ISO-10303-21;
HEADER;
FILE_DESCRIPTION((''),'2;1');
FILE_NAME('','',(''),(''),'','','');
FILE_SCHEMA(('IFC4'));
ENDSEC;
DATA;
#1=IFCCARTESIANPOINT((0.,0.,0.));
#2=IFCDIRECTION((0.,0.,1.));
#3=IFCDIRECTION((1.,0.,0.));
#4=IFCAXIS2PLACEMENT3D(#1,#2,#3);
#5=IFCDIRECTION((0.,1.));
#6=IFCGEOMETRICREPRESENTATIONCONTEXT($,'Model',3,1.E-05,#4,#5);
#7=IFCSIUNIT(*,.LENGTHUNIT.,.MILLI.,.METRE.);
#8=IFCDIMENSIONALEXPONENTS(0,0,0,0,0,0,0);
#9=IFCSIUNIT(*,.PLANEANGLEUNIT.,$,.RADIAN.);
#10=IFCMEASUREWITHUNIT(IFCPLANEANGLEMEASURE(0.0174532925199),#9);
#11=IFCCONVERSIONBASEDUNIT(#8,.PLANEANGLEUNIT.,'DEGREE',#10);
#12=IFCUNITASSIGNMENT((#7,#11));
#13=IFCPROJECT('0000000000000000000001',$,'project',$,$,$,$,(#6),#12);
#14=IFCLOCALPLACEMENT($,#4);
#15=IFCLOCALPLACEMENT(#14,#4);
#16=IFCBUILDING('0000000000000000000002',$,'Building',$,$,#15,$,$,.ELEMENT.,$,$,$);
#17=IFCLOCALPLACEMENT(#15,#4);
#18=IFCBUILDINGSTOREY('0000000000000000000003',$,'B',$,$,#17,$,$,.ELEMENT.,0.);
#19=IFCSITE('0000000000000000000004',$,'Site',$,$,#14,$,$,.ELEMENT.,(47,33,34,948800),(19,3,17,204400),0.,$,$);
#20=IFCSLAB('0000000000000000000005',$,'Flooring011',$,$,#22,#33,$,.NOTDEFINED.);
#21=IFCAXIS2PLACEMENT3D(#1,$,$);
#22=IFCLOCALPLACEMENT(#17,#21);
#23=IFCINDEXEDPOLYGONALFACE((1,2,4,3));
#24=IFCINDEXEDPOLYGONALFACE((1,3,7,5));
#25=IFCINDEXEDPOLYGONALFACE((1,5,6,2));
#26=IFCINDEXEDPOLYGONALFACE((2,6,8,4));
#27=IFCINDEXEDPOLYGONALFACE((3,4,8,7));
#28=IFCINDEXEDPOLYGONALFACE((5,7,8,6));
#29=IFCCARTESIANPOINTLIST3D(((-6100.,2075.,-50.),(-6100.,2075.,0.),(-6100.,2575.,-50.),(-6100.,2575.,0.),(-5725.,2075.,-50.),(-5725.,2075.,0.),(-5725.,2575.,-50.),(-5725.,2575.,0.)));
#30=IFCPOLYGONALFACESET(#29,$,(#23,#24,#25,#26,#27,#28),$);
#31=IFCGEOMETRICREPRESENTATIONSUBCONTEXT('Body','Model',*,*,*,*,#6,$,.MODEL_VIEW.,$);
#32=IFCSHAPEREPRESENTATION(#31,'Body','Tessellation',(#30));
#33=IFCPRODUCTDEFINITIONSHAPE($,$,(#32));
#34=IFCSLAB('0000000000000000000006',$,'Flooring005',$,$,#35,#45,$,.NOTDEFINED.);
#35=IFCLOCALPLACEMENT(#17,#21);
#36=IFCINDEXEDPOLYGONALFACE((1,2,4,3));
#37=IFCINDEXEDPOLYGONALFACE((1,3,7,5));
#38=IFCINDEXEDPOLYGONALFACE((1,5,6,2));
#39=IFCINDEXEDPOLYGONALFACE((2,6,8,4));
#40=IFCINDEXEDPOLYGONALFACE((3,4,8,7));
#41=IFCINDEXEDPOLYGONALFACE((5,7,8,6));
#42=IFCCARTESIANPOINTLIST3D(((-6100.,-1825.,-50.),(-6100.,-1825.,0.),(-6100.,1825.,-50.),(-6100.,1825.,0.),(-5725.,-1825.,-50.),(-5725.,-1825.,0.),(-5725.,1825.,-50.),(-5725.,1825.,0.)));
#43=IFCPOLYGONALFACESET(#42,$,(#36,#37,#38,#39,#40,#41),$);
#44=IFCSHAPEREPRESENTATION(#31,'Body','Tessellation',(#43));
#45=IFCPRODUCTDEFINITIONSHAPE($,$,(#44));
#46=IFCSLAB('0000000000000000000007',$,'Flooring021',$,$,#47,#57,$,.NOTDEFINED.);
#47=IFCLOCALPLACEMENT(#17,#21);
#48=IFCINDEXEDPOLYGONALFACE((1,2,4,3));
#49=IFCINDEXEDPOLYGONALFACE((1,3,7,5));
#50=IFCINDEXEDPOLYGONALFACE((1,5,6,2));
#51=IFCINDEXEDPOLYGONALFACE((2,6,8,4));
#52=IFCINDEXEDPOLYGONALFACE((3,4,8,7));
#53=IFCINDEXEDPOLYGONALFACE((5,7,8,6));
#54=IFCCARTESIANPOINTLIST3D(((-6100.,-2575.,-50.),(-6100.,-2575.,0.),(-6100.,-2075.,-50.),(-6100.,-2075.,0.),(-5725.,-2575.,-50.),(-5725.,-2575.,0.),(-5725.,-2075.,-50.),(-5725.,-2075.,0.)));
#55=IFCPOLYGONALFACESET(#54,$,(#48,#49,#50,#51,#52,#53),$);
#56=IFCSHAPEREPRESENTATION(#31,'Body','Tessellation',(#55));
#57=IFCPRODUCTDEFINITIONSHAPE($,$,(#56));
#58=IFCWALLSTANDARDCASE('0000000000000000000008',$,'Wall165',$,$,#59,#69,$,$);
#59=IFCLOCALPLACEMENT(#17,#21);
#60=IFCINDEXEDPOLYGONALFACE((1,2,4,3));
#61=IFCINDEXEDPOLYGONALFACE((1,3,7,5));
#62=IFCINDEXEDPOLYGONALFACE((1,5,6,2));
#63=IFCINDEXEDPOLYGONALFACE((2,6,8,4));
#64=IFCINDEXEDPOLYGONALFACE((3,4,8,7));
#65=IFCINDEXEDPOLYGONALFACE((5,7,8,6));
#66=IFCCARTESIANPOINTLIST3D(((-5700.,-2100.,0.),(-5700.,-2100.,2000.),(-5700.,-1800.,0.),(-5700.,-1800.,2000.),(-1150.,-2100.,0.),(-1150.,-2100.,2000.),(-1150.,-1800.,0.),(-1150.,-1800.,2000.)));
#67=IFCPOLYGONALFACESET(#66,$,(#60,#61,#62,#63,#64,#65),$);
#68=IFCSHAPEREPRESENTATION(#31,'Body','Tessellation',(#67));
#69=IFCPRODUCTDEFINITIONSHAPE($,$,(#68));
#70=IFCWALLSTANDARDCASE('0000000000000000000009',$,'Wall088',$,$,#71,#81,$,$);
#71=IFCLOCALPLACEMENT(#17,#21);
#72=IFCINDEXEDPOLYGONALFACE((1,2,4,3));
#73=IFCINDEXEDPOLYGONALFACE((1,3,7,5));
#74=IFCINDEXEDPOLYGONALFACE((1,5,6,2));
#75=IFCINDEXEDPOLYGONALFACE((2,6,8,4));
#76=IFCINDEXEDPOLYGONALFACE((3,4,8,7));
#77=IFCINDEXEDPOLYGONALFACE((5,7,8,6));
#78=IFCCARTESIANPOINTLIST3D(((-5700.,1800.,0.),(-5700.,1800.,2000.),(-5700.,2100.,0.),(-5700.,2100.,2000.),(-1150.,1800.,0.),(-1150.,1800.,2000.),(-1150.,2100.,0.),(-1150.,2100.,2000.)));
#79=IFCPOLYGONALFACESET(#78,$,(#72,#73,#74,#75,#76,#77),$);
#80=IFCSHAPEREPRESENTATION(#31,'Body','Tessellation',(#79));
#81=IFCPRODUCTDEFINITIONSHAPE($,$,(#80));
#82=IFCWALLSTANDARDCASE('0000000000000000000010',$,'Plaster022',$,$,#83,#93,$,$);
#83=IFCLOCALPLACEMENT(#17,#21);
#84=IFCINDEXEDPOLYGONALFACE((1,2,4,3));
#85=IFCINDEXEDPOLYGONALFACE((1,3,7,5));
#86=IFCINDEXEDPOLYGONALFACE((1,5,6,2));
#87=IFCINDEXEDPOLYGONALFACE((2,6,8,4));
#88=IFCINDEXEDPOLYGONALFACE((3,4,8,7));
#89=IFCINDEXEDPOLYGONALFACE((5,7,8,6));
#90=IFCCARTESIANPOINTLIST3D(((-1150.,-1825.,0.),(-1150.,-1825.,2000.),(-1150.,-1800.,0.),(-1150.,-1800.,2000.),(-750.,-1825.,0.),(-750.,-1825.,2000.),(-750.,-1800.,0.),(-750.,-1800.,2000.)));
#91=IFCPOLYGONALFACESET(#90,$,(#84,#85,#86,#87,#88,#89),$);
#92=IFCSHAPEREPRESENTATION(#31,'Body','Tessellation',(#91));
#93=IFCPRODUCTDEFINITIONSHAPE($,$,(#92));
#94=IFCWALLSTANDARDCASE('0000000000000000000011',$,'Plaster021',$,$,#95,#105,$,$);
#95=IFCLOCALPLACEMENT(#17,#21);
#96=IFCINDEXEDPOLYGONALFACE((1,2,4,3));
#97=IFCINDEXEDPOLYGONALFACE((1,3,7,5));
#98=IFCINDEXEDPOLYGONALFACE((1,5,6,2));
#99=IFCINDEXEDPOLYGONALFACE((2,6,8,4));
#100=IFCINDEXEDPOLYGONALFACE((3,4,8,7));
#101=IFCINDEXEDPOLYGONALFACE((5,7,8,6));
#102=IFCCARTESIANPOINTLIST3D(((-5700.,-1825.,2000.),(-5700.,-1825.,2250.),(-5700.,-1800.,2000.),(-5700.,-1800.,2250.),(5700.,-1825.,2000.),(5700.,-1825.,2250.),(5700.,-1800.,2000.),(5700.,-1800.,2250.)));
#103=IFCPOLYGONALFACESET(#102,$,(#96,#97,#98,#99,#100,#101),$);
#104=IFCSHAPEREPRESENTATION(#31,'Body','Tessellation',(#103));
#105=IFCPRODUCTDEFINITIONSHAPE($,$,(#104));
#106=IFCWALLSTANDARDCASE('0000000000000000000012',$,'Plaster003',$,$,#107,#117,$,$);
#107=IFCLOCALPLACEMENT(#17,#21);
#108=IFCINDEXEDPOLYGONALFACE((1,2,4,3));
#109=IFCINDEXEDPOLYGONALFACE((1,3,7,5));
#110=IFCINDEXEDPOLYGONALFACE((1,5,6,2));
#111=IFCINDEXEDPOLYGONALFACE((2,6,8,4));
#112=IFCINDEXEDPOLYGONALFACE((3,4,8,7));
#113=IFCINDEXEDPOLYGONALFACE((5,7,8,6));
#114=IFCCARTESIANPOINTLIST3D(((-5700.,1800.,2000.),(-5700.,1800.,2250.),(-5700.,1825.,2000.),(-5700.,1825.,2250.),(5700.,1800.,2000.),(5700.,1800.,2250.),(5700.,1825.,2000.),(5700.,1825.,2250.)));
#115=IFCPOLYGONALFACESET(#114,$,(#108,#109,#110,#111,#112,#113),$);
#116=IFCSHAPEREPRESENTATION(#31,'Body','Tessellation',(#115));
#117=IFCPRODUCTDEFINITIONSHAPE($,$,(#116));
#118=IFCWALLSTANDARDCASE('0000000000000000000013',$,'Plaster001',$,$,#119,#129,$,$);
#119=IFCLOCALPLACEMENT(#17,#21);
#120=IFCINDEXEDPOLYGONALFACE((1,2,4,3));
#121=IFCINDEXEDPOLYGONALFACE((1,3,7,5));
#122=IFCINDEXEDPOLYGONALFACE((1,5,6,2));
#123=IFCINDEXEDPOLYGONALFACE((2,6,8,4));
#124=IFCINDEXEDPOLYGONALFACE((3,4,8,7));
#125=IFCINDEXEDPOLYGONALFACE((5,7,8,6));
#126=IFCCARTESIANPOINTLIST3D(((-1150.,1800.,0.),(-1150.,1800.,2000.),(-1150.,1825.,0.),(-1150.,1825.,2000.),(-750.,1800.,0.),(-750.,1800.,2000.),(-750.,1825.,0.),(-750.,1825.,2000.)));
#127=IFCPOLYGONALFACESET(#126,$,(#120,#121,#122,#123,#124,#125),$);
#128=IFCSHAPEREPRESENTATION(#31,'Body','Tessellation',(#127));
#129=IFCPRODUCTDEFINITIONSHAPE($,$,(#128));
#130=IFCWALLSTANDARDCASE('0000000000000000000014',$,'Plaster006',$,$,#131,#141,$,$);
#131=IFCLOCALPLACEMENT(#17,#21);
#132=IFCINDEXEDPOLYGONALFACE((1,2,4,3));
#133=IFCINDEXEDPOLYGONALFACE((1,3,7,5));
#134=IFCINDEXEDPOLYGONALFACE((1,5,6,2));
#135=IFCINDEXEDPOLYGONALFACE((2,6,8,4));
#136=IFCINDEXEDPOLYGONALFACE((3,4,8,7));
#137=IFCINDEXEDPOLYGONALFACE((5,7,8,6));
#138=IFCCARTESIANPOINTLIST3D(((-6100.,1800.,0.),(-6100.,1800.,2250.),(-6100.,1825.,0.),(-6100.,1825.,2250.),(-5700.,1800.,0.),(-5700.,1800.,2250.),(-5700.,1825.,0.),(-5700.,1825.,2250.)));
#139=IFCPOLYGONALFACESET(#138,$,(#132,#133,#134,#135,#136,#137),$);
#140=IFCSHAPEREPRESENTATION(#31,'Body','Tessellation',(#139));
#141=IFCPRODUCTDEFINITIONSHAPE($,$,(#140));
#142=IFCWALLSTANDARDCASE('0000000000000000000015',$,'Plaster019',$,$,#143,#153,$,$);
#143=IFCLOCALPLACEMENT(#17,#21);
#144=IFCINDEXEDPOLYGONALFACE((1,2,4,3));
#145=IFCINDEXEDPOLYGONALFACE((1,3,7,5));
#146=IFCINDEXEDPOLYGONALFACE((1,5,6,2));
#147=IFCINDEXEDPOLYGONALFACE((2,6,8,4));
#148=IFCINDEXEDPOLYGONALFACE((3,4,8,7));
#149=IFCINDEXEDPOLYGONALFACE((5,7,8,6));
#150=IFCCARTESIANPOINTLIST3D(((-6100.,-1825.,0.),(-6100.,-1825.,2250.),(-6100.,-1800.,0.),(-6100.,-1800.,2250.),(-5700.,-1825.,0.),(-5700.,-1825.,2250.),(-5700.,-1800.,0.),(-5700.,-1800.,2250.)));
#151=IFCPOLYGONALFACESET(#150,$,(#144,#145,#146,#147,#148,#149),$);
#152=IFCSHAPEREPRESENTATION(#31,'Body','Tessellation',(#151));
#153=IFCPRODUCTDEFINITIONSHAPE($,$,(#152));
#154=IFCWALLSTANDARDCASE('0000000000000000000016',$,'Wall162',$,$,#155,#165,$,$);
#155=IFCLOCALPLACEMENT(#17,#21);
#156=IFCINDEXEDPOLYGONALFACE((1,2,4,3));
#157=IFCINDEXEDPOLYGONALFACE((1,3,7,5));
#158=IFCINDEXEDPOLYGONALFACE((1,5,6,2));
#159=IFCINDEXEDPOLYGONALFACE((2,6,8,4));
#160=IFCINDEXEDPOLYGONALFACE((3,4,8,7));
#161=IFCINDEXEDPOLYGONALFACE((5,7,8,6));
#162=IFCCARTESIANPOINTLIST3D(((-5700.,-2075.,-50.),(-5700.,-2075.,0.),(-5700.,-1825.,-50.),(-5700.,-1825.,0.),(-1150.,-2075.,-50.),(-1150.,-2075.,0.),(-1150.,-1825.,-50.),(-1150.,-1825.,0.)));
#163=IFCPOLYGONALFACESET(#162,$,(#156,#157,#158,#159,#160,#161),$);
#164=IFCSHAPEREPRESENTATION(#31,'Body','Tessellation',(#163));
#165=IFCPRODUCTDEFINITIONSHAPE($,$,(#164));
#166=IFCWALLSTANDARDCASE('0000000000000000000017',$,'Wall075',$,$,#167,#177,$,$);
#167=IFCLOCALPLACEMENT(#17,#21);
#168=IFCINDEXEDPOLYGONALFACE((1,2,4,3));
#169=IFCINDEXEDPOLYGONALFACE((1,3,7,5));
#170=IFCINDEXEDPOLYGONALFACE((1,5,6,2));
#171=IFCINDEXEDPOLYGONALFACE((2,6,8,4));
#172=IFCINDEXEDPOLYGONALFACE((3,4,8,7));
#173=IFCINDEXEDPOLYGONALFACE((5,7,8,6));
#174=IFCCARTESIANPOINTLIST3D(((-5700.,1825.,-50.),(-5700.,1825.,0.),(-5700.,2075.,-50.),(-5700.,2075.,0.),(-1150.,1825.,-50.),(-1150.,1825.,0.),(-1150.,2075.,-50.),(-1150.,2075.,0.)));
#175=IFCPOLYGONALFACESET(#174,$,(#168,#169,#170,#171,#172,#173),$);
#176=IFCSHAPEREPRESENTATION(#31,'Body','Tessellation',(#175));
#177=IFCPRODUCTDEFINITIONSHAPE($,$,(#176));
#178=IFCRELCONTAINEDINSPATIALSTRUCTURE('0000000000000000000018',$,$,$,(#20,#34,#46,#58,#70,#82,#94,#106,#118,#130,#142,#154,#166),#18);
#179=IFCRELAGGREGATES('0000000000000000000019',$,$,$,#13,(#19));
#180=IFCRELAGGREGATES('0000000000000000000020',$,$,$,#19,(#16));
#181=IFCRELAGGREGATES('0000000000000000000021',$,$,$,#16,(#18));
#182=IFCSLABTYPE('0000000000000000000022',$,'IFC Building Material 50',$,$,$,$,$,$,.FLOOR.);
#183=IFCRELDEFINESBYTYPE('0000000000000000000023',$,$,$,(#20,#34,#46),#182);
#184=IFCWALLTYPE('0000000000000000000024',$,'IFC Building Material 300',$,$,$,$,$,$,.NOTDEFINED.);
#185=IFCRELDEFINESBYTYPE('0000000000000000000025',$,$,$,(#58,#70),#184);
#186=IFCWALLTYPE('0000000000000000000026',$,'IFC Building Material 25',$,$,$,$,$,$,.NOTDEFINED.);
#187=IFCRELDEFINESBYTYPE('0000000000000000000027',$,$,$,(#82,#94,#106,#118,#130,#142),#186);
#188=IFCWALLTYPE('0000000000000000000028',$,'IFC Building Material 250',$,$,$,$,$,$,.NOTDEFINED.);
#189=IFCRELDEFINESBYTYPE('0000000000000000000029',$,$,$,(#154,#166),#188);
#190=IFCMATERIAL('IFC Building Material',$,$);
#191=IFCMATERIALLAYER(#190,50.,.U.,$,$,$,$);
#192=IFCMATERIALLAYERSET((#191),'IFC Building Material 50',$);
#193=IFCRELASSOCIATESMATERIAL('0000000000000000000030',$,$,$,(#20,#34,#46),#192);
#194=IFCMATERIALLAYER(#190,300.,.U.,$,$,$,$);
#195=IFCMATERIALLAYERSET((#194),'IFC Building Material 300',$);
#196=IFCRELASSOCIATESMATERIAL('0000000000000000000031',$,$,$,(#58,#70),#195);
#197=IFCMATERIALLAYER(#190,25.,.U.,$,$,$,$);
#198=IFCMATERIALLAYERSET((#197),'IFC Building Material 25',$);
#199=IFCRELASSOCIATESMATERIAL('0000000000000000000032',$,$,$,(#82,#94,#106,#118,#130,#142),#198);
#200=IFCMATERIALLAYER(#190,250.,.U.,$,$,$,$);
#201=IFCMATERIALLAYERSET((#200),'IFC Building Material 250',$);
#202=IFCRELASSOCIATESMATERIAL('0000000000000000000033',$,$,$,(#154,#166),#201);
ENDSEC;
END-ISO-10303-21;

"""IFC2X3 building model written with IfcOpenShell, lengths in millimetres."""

from ifc_helpers import new_model, entity, si_unit, converted_unit, direction, frame, origin_with_axes, place, context, subcontext, project, spatial, polyline, outline, extrude, material, layer, layer_set, layer_usage, type_object, element, save


model = new_model("IFC2X3")

# Units and contexts
model_context = context("Model", 3, precision=1e-05, world=origin_with_axes(), true_north=direction((0.0, 1.0)))
body_context = subcontext(model_context, "Body", "Model", "MODEL_VIEW")
ifc_project = project(units=[si_unit("LENGTHUNIT", "METRE", prefix="MILLI"), converted_unit("PLANEANGLEUNIT", "DEGREE", entity("IfcPlaneAngleMeasure", 0.0174532925199), si_unit("PLANEANGLEUNIT", "RADIAN"), dimensions=[0, 0, 0, 0, 0, 0, 0])], contexts=[model_context])

# Site, building, storey
site_placement = place(None, origin_with_axes())
site = spatial("IfcSite", under=ifc_project, at=site_placement, Name="Site", CompositionType="ELEMENT", RefLatitude=(47, 33, 34, 948800), RefLongitude=(19, 3, 17, 204400), RefElevation=0.0)
building_placement = place(site_placement, origin_with_axes())
building = spatial("IfcBuilding", under=site, at=building_placement, Name="Building", CompositionType="ELEMENT")
storey_placement = place(building_placement, origin_with_axes())
storey = spatial("IfcBuildingStorey", under=building, at=storey_placement, Name="B", CompositionType="ELEMENT", Elevation=0.0)

# Shared definitions
ifc_material = material(Name="IFC Building Material")

# Slabs
ifc_layer_1 = layer(ifc_material, 250.0, ventilated="UNKNOWN")
ifc_layer_set_1 = layer_set([ifc_layer_1], Name="IFC Building Material 250")
ifc_layer_2 = layer(ifc_material, 50.0, ventilated="UNKNOWN")
ifc_layer_set_2 = layer_set([ifc_layer_2], Name="IFC Building Material 50")
ifc_layer_usage_1 = layer_usage(ifc_layer_set_2, "AXIS3", "NEGATIVE", 50.0)
slab_type_1 = type_object("IfcSlabType", Name="IFC Building Material 50", PredefinedType="FLOOR")
slab_1_placement = place(storey_placement, frame((-6100.0, 2575.0, 0.0), z_axis=(0.0, 0.0, 1.0), x_axis=(1.0, 0.0, 0.0)))
element("IfcSlab", 1, at=slab_1_placement, inside=storey, type_object=slab_type_1, material=ifc_layer_usage_1, Name="Flooring011", PredefinedType="NOTDEFINED", context=body_context, shape_type="SweptSolid", body=[
    extrude(outline(polyline([(0.0, 0.0), (0.0, -500.0), (375.0, -500.0), (375.0, 0.0), (0.0, 0.0)])), frame((0.0, 0.0, -50.0), z_axis=(0.0, 0.0, 1.0), x_axis=(1.0, 0.0, 0.0)), (0.0, 0.0, 1.0), 50.0),
])
ifc_layer_usage_2 = layer_usage(ifc_layer_set_2, "AXIS3", "NEGATIVE", 50.0)
slab_2_placement = place(storey_placement, frame((-6100.0, -1825.0, 0.0), z_axis=(0.0, 0.0, 1.0), x_axis=(1.0, 0.0, 0.0)))
element("IfcSlab", 2, at=slab_2_placement, inside=storey, type_object=slab_type_1, material=ifc_layer_usage_2, Name="Flooring005", PredefinedType="NOTDEFINED", context=body_context, shape_type="SweptSolid", body=[
    extrude(outline(polyline([(0.0, 0.0), (375.0, 0.0), (375.0, 3650.0), (0.0, 3650.0), (0.0, 0.0)])), frame((0.0, 0.0, -50.0), z_axis=(0.0, 0.0, 1.0), x_axis=(1.0, 0.0, 0.0)), (0.0, 0.0, 1.0), 50.0),
])
ifc_layer_usage_3 = layer_usage(ifc_layer_set_2, "AXIS3", "NEGATIVE", 50.0)
slab_3_placement = place(storey_placement, frame((-6100.0, -2575.0, 0.0), z_axis=(0.0, 0.0, 1.0), x_axis=(1.0, 0.0, 0.0)))
element("IfcSlab", 3, at=slab_3_placement, inside=storey, type_object=slab_type_1, material=ifc_layer_usage_3, Name="Flooring021", PredefinedType="NOTDEFINED", context=body_context, shape_type="SweptSolid", body=[
    extrude(outline(polyline([(0.0, 0.0), (375.0, 0.0), (375.0, 500.0), (0.0, 500.0), (0.0, 0.0)])), frame((0.0, 0.0, -50.0), z_axis=(0.0, 0.0, 1.0), x_axis=(1.0, 0.0, 0.0)), (0.0, 0.0, 1.0), 50.0),
])

# Walls
ifc_layer_3 = layer(ifc_material, 300.0, ventilated="UNKNOWN")
ifc_layer_set_3 = layer_set([ifc_layer_3], Name="IFC Building Material 300")
ifc_layer_usage_4 = layer_usage(ifc_layer_set_3, "AXIS2", "NEGATIVE", 300.0)
wall_type_1 = type_object("IfcWallType", Name="IFC Building Material 300", PredefinedType="NOTDEFINED")
wall_1_placement = place(storey_placement, frame((-1150.0, -1800.0, 0.0), z_axis=(0.0, 0.0, 1.0), x_axis=(-1.0, 0.0, 0.0)))
element("IfcWallStandardCase", 4, at=wall_1_placement, inside=storey, type_object=wall_type_1, material=ifc_layer_usage_4, Name="Wall165", context=body_context, shape_type="SweptSolid", body=[
    extrude(outline(polyline([(0.0, 0.0), (4550.0, 0.0), (4550.0, 300.0), (0.0, 300.0), (0.0, 0.0)])), origin_with_axes(), (0.0, 0.0, 1.0), 2000.0),
])
ifc_layer_usage_5 = layer_usage(ifc_layer_set_3, "AXIS2", "NEGATIVE", 0.0)
wall_2_placement = place(storey_placement, frame((-1150.0, 1800.0, 0.0), z_axis=(0.0, 0.0, 1.0), x_axis=(-1.0, 0.0, 0.0)))
element("IfcWallStandardCase", 5, at=wall_2_placement, inside=storey, type_object=wall_type_1, material=ifc_layer_usage_5, Name="Wall088", context=body_context, shape_type="SweptSolid", body=[
    extrude(outline(polyline([(0.0, -300.0), (4550.0, -300.0), (4550.0, 0.0), (0.0, 0.0), (0.0, -300.0)])), origin_with_axes(), (0.0, 0.0, 1.0), 2000.0),
])
ifc_layer_4 = layer(ifc_material, 25.0, ventilated="UNKNOWN")
ifc_layer_set_4 = layer_set([ifc_layer_4], Name="IFC Building Material 25")
ifc_layer_usage_6 = layer_usage(ifc_layer_set_4, "AXIS2", "POSITIVE", -25.0)
wall_type_2 = type_object("IfcWallType", Name="IFC Building Material 25", PredefinedType="NOTDEFINED")
wall_3_placement = place(storey_placement, frame((-1150.0, -1800.0, 0.0), z_axis=(0.0, 0.0, 1.0), x_axis=(1.0, 0.0, 0.0)))
element("IfcWallStandardCase", 6, at=wall_3_placement, inside=storey, type_object=wall_type_2, material=ifc_layer_usage_6, Name="Plaster022", context=body_context, shape_type="SweptSolid", body=[
    extrude(outline(polyline([(0.0, -25.0), (400.0, -25.0), (400.0, 0.0), (0.0, 0.0), (0.0, -25.0)])), origin_with_axes(), (0.0, 0.0, 1.0), 2000.0),
])
ifc_layer_usage_7 = layer_usage(ifc_layer_set_4, "AXIS2", "POSITIVE", -25.0)
wall_4_placement = place(storey_placement, frame((-5700.0, -1800.0, 2000.0), z_axis=(0.0, 0.0, 1.0), x_axis=(1.0, 0.0, 0.0)))
element("IfcWallStandardCase", 7, at=wall_4_placement, inside=storey, type_object=wall_type_2, material=ifc_layer_usage_7, Name="Plaster021", context=body_context, shape_type="SweptSolid", body=[
    extrude(outline(polyline([(0.0, -25.0), (11400.0, -25.0), (11400.0, 0.0), (0.0, 0.0), (0.0, -25.0)])), origin_with_axes(), (0.0, 0.0, 1.0), 250.0),
])
ifc_layer_usage_8 = layer_usage(ifc_layer_set_4, "AXIS2", "POSITIVE", 0.0)
wall_5_placement = place(storey_placement, frame((-5700.0, 1800.0, 2000.0), z_axis=(0.0, 0.0, 1.0), x_axis=(1.0, 0.0, 0.0)))
element("IfcWallStandardCase", 8, at=wall_5_placement, inside=storey, type_object=wall_type_2, material=ifc_layer_usage_8, Name="Plaster003", context=body_context, shape_type="SweptSolid", body=[
    extrude(outline(polyline([(0.0, 0.0), (11400.0, 0.0), (11400.0, 25.0), (0.0, 25.0), (0.0, 0.0)])), origin_with_axes(), (0.0, 0.0, 1.0), 250.0),
])
ifc_layer_usage_9 = layer_usage(ifc_layer_set_4, "AXIS2", "POSITIVE", 0.0)
wall_6_placement = place(storey_placement, frame((-1150.0, 1800.0, 0.0), z_axis=(0.0, 0.0, 1.0), x_axis=(1.0, 0.0, 0.0)))
element("IfcWallStandardCase", 9, at=wall_6_placement, inside=storey, type_object=wall_type_2, material=ifc_layer_usage_9, Name="Plaster001", context=body_context, shape_type="SweptSolid", body=[
    extrude(outline(polyline([(0.0, 0.0), (400.0, 0.0), (400.0, 25.0), (0.0, 25.0), (0.0, 0.0)])), origin_with_axes(), (0.0, 0.0, 1.0), 2000.0),
])
ifc_layer_usage_10 = layer_usage(ifc_layer_set_4, "AXIS2", "POSITIVE", 0.0)
wall_7_placement = place(storey_placement, frame((-6100.0, 1800.0, 0.0), z_axis=(0.0, 0.0, 1.0), x_axis=(1.0, 0.0, 0.0)))
element("IfcWallStandardCase", 10, at=wall_7_placement, inside=storey, type_object=wall_type_2, material=ifc_layer_usage_10, Name="Plaster006", context=body_context, shape_type="SweptSolid", body=[
    extrude(outline(polyline([(0.0, 0.0), (400.0, 0.0), (400.0, 25.0), (0.0, 25.0), (0.0, 0.0)])), origin_with_axes(), (0.0, 0.0, 1.0), 2250.0),
])
ifc_layer_usage_11 = layer_usage(ifc_layer_set_4, "AXIS2", "POSITIVE", -25.0)
wall_8_placement = place(storey_placement, frame((-6100.0, -1800.0, 0.0), z_axis=(0.0, 0.0, 1.0), x_axis=(1.0, 0.0, 0.0)))
element("IfcWallStandardCase", 11, at=wall_8_placement, inside=storey, type_object=wall_type_2, material=ifc_layer_usage_11, Name="Plaster019", context=body_context, shape_type="SweptSolid", body=[
    extrude(outline(polyline([(0.0, -25.0), (400.0, -25.0), (400.0, 0.0), (0.0, 0.0), (0.0, -25.0)])), origin_with_axes(), (0.0, 0.0, 1.0), 2250.0),
])
ifc_layer_usage_12 = layer_usage(ifc_layer_set_1, "AXIS2", "POSITIVE", -250.0)
wall_type_3 = type_object("IfcWallType", Name="IFC Building Material 250", PredefinedType="NOTDEFINED")
wall_9_placement = place(storey_placement, frame((-1150.0, -2075.0, -50.0), z_axis=(0.0, 0.0, 1.0), x_axis=(-1.0, 0.0, 0.0)))
element("IfcWallStandardCase", 12, at=wall_9_placement, inside=storey, type_object=wall_type_3, material=ifc_layer_usage_12, Name="Wall162", context=body_context, shape_type="SweptSolid", body=[
    extrude(outline(polyline([(0.0, -250.0), (4550.0, -250.0), (4550.0, 0.0), (0.0, 0.0), (0.0, -250.0)])), origin_with_axes(), (0.0, 0.0, 1.0), 50.0),
])
ifc_layer_usage_13 = layer_usage(ifc_layer_set_1, "AXIS2", "POSITIVE", 0.0)
wall_10_placement = place(storey_placement, frame((-1150.0, 2075.0, -50.0), z_axis=(0.0, 0.0, 1.0), x_axis=(-1.0, 0.0, 0.0)))
element("IfcWallStandardCase", 13, at=wall_10_placement, inside=storey, type_object=wall_type_3, material=ifc_layer_usage_13, Name="Wall075", context=body_context, shape_type="SweptSolid", body=[
    extrude(outline(polyline([(0.0, 0.0), (4550.0, 0.0), (4550.0, 250.0), (0.0, 250.0), (0.0, 0.0)])), origin_with_axes(), (0.0, 0.0, 1.0), 50.0),
])

save(model, "model.ifc")
